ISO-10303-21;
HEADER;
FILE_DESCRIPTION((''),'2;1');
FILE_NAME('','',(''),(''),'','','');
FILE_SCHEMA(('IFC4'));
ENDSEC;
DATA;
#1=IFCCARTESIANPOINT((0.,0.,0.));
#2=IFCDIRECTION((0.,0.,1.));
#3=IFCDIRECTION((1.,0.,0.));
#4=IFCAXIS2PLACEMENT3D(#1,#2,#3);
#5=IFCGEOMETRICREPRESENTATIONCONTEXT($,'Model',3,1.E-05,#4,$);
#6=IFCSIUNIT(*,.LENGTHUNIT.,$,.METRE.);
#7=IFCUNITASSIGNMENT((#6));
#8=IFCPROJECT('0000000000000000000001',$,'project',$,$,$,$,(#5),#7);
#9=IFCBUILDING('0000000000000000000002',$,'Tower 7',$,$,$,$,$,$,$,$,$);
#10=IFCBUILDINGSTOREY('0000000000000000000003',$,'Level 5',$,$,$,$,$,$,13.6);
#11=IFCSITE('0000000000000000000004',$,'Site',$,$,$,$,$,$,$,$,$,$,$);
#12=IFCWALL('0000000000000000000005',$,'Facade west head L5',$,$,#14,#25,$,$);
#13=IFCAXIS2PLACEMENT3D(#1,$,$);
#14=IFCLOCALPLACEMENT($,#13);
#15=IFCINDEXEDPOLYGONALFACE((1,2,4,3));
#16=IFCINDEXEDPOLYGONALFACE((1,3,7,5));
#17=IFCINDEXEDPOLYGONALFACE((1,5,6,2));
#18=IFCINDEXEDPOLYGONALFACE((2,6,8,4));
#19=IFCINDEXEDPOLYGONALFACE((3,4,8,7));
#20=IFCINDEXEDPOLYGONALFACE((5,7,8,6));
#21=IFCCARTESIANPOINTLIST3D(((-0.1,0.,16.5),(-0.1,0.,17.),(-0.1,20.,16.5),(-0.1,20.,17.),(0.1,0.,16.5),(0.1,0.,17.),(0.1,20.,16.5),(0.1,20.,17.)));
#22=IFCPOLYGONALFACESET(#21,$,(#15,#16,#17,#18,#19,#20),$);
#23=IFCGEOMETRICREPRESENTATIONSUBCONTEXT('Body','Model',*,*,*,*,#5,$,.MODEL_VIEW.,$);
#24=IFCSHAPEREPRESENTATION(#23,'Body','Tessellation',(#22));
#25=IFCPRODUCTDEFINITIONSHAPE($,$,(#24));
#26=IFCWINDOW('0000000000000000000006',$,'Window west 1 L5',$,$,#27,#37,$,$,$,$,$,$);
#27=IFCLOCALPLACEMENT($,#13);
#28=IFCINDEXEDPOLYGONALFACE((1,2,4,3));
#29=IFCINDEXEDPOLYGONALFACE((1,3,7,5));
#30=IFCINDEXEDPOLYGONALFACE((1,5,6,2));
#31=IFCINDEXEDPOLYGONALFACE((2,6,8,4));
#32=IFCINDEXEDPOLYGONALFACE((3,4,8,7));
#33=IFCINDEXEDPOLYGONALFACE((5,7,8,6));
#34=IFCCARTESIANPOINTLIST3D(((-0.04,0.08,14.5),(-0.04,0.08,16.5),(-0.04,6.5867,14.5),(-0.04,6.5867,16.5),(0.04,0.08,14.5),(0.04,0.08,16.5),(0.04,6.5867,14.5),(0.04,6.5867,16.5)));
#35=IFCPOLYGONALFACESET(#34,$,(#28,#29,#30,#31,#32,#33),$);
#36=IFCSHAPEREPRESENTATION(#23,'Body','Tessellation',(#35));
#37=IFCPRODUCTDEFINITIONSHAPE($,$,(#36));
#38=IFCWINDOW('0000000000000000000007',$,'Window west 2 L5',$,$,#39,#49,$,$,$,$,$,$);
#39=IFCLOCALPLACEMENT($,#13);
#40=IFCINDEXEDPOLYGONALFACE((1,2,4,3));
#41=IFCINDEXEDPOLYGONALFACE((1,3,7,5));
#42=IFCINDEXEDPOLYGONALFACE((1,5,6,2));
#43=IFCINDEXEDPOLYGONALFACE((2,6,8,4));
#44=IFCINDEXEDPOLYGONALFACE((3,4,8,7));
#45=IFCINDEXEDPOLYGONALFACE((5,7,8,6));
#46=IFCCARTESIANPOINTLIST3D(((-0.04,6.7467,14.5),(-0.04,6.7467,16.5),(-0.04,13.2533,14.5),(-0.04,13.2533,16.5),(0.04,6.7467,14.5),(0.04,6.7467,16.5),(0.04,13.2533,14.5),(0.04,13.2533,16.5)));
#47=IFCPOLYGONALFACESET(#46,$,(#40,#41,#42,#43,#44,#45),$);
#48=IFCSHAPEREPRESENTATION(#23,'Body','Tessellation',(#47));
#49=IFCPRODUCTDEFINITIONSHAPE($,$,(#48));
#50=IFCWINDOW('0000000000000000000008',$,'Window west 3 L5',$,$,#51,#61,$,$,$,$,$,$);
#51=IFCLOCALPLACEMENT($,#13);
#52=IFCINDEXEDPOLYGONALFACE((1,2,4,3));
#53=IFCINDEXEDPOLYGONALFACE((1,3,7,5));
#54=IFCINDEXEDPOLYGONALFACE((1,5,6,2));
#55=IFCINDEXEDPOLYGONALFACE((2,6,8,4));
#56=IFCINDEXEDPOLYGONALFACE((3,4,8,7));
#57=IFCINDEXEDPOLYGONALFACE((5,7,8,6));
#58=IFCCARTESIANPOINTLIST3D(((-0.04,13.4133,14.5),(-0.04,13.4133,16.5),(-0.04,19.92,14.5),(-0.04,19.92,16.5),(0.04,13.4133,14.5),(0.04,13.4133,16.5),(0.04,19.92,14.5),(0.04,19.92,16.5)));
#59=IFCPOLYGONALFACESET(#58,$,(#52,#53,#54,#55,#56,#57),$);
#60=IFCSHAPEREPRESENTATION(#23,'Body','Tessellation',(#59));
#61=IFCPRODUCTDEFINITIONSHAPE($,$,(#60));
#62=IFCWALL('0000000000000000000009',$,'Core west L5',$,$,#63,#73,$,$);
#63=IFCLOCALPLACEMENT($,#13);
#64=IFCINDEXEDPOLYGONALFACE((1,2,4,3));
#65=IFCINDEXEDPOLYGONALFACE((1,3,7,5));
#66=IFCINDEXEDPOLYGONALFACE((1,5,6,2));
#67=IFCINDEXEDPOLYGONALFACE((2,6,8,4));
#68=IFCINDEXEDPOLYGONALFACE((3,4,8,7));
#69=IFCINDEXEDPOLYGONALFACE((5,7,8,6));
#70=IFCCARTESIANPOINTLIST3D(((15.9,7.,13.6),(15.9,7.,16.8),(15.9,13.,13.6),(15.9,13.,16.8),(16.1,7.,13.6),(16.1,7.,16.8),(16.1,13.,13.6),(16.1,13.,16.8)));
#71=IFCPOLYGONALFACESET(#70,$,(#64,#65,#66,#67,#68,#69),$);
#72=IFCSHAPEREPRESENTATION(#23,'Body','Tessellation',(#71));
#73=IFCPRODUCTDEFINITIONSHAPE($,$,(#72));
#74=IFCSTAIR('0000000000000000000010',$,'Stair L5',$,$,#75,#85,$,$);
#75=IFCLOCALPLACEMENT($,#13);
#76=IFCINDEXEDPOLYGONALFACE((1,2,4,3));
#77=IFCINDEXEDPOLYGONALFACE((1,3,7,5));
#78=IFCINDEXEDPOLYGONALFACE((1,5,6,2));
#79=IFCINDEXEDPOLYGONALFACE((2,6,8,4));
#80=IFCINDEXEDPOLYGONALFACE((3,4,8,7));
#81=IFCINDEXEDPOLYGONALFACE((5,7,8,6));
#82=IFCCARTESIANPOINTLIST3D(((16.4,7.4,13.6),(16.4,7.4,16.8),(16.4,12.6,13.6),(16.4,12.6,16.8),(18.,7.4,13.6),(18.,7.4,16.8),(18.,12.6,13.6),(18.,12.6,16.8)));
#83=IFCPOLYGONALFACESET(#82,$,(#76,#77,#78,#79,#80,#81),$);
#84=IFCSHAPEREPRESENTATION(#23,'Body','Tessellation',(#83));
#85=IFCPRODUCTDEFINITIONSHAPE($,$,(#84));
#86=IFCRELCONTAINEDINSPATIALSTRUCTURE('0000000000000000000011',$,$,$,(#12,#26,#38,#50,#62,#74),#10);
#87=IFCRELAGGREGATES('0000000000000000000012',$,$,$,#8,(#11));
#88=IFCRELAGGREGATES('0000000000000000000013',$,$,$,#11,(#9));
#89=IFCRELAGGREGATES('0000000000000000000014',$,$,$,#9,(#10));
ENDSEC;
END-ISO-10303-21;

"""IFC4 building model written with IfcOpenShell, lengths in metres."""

from ifc_helpers import new_model, si_unit, frame, origin, origin_with_axes, origin_2d, place, context, subcontext, project, spatial, rectangle, extrude, element, save


model = new_model("IFC4")

# Units and contexts
model_context = context("Model", 3, precision=1e-05, world=origin_with_axes())
body_context = subcontext(model_context, "Body", "Model", "MODEL_VIEW")
ifc_project = project(units=[si_unit("LENGTHUNIT", "METRE")], contexts=[model_context])

# Site, building, storey
site = spatial("IfcSite", under=ifc_project, Name="Site")
building = spatial("IfcBuilding", under=site, Name="Tower 7")
storey = spatial("IfcBuildingStorey", under=building, Name="Level 5", Elevation=13.6)

# Wall
wall_1_placement = place(None, frame((0.0, 10.0, 16.5), z_axis=(0.0, 0.0, 1.0), x_axis=(1.0, 0.0, 0.0)))
element("IfcWall", 1, at=wall_1_placement, inside=storey, Name="Facade west head L5", context=body_context, shape_type="SweptSolid", body=[
    extrude(rectangle(XDim=0.2, YDim=20.0, at=origin_2d()), origin(), (0.0, 0.0, 1.0), 0.5),
])

# Windows
for number, where, z_axis, x_axis, name in (
    (2, (0.0, 3.3333, 14.5), (0.0, 0.0, 1.0), (1.0, 0.0, 0.0), "Window west 1 L5"),
    (3, (0.0, 10.0, 14.5), (0.0, 0.0, 1.0), (1.0, 0.0, 0.0), "Window west 2 L5"),
):
    element("IfcWindow", number, at=place(None, frame(where, z_axis=z_axis, x_axis=x_axis)), inside=storey, Name=name, context=body_context, shape_type="SweptSolid", body=[
        extrude(rectangle(XDim=0.08, YDim=6.5067, at=origin_2d()), origin(), (0.0, 0.0, 1.0), 2.0),
    ])
window_1_placement = place(None, frame((0.0, 16.6667, 14.5), z_axis=(0.0, 0.0, 1.0), x_axis=(1.0, 0.0, 0.0)))
element("IfcWindow", 4, at=window_1_placement, inside=storey, Name="Window west 3 L5", context=body_context, shape_type="SweptSolid", body=[
    extrude(rectangle(XDim=0.08, YDim=6.5067, at=origin_2d()), origin(), (0.0, 0.0, 1.0), 2.0),
])

# Wall
wall_2_placement = place(None, frame((16.0, 10.0, 13.6), z_axis=(0.0, 0.0, 1.0), x_axis=(1.0, 0.0, 0.0)))
element("IfcWall", 5, at=wall_2_placement, inside=storey, Name="Core west L5", context=body_context, shape_type="SweptSolid", body=[
    extrude(rectangle(XDim=0.2, YDim=6.0, at=origin_2d()), origin(), (0.0, 0.0, 1.0), 3.2),
])

# Stair
stair_placement = place(None, frame((17.2, 10.0, 13.6), z_axis=(0.0, 0.0, 1.0), x_axis=(1.0, 0.0, 0.0)))
element("IfcStair", 6, at=stair_placement, inside=storey, Name="Stair L5", context=body_context, shape_type="SweptSolid", body=[
    extrude(rectangle(XDim=1.6, YDim=5.2, at=origin_2d()), origin(), (0.0, 0.0, 1.0), 3.2),
])

save(model, "model.ifc")
